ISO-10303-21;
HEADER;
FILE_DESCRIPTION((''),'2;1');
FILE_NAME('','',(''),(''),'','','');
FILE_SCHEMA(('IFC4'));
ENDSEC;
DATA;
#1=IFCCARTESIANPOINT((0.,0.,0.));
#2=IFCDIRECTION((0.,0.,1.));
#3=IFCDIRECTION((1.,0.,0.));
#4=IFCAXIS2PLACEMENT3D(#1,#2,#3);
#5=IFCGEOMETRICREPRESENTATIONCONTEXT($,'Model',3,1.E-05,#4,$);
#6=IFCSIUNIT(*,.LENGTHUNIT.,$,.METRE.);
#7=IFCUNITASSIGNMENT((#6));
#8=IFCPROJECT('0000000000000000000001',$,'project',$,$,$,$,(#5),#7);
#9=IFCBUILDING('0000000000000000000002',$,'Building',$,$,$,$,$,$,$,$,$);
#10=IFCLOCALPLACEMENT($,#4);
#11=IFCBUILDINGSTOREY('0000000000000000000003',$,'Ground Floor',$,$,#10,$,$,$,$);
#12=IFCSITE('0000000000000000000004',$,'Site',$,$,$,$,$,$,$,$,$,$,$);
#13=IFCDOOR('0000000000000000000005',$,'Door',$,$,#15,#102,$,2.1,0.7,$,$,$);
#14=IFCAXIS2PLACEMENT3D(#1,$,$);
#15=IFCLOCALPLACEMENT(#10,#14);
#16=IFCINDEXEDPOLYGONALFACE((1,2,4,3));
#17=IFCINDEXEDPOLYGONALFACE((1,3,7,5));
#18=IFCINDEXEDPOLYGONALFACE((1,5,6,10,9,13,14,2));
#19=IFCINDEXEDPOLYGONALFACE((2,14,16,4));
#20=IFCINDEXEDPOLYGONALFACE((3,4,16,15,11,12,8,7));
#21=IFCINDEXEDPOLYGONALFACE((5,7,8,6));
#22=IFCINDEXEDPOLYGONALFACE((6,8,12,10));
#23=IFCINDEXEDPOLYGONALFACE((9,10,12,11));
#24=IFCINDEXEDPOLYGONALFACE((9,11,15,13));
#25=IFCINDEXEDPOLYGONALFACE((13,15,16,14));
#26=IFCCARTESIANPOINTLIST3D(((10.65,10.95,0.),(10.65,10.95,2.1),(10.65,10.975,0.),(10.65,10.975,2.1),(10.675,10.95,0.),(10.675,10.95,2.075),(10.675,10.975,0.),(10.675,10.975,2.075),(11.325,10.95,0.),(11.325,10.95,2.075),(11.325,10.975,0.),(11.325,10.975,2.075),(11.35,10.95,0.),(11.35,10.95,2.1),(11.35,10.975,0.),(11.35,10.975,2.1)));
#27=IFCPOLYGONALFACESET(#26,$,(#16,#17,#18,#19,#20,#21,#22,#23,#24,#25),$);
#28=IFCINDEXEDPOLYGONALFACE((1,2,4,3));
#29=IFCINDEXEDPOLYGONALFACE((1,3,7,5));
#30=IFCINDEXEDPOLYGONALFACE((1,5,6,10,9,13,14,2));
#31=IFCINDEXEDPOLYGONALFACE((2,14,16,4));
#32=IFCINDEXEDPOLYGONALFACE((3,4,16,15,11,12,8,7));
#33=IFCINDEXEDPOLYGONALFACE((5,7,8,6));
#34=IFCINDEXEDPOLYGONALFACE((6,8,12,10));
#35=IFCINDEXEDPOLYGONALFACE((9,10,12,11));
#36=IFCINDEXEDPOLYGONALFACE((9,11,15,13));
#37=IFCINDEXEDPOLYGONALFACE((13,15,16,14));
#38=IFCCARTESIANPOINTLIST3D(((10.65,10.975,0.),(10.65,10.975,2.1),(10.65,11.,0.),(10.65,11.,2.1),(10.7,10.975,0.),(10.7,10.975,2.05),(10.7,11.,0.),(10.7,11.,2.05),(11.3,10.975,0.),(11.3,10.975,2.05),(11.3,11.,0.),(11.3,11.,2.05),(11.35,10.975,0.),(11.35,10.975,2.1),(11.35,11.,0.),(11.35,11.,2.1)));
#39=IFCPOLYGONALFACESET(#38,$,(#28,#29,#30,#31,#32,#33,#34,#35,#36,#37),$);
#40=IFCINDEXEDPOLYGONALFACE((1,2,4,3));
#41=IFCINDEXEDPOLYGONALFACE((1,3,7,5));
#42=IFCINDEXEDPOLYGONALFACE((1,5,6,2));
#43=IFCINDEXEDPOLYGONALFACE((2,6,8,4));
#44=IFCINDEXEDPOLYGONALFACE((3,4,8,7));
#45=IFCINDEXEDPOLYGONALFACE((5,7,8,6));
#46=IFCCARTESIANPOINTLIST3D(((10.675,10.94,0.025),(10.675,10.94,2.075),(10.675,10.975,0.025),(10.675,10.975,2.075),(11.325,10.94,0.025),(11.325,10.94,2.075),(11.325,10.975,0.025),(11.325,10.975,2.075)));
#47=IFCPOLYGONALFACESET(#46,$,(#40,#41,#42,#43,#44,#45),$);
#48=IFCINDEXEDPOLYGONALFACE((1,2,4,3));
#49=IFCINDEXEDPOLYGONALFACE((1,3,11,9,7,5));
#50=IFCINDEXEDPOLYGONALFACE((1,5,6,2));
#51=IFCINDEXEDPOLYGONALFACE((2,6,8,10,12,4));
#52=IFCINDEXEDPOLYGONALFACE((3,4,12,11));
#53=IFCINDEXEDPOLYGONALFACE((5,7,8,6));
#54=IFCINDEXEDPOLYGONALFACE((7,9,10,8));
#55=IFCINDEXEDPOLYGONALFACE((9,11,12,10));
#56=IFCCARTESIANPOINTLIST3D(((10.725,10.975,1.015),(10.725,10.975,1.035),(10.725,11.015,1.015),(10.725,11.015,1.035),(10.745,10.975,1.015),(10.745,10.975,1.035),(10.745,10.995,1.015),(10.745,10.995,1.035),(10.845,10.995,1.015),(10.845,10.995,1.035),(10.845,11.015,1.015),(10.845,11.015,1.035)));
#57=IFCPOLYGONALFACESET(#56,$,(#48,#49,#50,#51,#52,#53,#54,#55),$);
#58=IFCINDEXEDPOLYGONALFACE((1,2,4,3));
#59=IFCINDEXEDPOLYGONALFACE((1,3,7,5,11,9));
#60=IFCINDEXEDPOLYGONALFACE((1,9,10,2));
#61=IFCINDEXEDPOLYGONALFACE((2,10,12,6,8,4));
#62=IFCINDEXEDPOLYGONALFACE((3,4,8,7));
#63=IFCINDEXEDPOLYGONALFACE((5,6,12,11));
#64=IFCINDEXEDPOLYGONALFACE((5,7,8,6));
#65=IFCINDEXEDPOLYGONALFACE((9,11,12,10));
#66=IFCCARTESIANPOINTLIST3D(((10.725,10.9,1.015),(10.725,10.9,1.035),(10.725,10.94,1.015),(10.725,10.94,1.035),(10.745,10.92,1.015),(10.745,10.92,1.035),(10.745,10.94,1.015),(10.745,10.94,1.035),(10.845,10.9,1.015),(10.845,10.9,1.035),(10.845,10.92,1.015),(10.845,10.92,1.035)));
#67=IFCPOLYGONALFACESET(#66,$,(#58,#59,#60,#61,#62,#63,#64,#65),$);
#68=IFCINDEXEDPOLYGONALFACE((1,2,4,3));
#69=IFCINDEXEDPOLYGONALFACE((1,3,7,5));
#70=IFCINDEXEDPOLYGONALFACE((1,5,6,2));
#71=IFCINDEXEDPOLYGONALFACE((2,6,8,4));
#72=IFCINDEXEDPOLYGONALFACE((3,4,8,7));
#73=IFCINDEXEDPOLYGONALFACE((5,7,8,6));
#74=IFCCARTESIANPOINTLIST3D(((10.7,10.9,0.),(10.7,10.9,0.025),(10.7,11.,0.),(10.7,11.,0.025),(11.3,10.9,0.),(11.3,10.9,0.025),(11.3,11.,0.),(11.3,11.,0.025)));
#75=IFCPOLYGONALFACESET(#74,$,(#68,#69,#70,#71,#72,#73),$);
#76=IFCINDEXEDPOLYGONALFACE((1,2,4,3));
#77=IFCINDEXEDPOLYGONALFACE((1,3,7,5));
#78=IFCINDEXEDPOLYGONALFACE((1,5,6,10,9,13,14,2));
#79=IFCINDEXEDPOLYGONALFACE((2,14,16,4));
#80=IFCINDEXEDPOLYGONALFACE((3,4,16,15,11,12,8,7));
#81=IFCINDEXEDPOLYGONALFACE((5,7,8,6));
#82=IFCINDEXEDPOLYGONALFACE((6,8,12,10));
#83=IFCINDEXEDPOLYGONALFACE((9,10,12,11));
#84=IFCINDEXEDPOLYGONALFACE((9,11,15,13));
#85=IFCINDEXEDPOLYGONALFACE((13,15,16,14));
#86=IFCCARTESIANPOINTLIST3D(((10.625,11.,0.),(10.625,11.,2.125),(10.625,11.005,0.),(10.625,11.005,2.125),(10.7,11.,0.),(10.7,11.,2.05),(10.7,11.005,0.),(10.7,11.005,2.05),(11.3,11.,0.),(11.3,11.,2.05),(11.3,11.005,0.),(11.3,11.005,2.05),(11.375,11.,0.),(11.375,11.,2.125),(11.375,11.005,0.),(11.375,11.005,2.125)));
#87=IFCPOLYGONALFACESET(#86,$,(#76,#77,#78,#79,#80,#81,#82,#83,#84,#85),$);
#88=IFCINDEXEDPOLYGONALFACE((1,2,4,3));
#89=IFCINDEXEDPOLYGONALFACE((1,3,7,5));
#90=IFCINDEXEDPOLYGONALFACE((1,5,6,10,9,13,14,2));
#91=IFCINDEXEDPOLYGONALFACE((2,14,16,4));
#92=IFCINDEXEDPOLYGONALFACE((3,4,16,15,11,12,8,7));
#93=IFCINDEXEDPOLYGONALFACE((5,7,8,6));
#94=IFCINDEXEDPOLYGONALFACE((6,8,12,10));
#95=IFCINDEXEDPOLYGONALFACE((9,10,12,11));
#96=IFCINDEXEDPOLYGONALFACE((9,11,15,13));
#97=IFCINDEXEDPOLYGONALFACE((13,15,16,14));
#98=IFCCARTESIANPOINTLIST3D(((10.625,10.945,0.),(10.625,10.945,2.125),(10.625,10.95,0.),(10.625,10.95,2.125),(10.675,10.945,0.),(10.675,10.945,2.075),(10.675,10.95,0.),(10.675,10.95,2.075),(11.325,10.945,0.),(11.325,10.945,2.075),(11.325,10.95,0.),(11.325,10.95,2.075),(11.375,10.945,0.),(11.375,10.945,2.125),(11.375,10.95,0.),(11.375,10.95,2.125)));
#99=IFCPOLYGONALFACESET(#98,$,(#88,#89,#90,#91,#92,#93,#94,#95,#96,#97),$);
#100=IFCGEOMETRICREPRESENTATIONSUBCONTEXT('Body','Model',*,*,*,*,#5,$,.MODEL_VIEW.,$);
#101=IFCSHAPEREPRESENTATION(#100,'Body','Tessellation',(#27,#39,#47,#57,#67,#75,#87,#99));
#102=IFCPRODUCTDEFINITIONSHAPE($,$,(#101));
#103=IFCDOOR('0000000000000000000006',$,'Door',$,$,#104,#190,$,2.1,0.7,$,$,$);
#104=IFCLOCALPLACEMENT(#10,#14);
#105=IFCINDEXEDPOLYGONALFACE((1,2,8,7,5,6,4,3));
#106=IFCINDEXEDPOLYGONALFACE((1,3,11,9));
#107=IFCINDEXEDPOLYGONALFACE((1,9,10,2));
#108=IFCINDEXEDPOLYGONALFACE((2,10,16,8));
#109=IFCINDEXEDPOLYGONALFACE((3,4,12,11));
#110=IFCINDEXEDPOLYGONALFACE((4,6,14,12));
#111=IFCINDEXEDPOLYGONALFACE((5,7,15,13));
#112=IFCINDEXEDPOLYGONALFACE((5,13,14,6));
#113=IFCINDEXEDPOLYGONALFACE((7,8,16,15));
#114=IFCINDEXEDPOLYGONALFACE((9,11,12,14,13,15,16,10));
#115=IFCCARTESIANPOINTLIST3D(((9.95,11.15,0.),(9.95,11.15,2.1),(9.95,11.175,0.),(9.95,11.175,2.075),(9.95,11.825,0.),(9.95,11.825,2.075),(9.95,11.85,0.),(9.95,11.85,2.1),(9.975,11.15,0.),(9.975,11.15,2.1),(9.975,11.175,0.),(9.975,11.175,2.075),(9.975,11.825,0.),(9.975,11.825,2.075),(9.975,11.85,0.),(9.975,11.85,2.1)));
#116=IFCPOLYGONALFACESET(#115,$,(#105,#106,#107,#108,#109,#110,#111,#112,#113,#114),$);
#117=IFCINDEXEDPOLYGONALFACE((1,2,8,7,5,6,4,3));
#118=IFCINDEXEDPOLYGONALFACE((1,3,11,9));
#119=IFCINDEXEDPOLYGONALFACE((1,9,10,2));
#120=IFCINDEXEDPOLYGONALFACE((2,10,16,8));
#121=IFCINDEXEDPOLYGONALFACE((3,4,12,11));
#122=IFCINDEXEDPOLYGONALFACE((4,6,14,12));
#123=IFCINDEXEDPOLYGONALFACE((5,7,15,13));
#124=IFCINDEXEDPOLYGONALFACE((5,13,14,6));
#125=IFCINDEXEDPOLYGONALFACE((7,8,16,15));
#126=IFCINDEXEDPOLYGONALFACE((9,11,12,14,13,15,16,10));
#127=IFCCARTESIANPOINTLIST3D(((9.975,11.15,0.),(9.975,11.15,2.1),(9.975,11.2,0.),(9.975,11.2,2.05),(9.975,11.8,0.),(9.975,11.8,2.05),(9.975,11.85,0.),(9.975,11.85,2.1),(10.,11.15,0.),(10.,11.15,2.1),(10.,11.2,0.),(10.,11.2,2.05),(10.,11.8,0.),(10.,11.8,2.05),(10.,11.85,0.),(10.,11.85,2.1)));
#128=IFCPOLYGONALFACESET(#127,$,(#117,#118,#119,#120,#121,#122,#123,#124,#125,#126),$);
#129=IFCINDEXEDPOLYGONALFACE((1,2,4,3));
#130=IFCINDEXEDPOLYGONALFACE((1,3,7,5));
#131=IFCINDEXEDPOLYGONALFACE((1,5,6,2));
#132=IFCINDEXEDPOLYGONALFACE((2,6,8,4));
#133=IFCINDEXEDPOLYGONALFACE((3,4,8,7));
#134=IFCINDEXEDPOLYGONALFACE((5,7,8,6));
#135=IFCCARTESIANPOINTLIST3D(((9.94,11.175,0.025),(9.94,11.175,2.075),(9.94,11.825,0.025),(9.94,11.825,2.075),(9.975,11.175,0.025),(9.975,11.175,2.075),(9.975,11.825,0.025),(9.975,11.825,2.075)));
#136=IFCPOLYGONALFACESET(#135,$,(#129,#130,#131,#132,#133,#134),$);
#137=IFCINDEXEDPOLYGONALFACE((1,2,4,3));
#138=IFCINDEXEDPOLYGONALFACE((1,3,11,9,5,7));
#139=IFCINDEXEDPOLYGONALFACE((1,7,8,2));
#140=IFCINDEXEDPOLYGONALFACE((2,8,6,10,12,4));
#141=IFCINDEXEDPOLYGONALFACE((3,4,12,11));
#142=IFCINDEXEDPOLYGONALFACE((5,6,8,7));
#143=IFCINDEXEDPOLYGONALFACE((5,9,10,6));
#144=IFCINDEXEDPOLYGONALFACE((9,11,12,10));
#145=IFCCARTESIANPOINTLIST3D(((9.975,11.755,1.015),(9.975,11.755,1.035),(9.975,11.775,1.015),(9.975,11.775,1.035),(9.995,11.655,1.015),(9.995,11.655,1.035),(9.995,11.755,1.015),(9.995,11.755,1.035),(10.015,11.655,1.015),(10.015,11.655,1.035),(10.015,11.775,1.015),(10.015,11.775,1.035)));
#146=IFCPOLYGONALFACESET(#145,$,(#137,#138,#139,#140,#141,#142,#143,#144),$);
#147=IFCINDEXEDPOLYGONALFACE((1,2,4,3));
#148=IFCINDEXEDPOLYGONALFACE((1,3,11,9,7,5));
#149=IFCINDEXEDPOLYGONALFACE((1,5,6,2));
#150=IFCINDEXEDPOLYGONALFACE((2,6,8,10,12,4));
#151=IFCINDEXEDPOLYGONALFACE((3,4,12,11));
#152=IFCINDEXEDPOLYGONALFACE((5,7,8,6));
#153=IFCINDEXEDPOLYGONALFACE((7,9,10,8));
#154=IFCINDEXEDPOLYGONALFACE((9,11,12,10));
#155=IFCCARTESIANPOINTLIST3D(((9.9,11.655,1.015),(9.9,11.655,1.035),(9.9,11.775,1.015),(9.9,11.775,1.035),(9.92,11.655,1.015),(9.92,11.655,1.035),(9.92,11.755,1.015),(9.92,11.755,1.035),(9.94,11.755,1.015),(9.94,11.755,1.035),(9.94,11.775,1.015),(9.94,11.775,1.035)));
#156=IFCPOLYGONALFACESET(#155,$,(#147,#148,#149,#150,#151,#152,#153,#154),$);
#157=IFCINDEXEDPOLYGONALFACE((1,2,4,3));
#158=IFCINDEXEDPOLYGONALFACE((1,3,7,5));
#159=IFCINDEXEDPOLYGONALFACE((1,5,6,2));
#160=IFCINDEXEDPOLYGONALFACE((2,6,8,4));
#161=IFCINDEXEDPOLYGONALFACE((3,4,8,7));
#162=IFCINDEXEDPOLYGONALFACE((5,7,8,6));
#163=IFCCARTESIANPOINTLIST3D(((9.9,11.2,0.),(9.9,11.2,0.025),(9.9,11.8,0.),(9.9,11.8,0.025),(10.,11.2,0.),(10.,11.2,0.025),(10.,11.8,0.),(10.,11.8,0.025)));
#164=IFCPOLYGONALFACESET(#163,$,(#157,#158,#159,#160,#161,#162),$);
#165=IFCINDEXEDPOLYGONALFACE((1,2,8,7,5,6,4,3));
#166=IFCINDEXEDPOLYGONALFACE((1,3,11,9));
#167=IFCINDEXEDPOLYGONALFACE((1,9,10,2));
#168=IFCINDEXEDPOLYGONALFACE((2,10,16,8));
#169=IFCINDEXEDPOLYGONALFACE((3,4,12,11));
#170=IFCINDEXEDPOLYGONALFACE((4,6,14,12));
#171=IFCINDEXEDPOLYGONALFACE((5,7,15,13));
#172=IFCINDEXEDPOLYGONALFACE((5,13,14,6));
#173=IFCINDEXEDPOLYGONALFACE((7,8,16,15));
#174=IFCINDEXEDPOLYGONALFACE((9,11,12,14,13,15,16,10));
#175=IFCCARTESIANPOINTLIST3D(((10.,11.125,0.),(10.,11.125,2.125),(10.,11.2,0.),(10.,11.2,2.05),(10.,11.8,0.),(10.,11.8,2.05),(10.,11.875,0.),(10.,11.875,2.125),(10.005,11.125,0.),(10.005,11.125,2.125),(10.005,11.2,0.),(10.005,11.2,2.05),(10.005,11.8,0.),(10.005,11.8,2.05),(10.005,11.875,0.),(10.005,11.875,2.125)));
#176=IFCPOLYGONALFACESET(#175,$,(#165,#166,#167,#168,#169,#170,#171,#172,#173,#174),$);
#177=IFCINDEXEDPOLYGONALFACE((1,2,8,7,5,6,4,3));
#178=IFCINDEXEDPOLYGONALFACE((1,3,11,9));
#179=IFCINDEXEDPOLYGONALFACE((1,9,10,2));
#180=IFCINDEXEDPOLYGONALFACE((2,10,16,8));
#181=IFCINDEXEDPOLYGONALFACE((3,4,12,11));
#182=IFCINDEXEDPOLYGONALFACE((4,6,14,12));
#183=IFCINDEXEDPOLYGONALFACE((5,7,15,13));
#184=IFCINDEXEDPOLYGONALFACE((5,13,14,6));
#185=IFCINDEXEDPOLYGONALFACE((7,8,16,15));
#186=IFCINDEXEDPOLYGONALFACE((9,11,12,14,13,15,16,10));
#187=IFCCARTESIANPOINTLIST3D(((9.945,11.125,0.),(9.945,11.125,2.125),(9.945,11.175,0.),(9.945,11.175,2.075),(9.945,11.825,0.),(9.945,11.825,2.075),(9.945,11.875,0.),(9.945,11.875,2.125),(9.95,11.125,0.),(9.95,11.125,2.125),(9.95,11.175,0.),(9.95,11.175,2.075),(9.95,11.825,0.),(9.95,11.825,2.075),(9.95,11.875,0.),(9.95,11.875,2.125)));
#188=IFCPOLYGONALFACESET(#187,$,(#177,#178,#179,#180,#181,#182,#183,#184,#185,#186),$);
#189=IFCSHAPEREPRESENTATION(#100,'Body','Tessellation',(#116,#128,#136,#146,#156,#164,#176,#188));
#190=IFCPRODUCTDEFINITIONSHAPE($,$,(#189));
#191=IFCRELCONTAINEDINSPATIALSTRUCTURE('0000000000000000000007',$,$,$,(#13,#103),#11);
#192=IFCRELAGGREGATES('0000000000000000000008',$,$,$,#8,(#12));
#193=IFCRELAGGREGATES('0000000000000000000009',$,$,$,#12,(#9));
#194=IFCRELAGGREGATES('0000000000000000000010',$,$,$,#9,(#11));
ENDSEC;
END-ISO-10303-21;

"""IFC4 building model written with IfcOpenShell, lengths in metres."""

from ifc_helpers import new_model, si_unit, frame, origin_with_axes, place, context, subcontext, project, spatial, line, indexed_curve, outline, extrude, element, save


model = new_model("IFC4")

# Units and contexts
model_context = context("Model", 3, precision=1e-05, world=origin_with_axes())
body_context = subcontext(model_context, "Body", "Model", "MODEL_VIEW")
ifc_project = project(units=[si_unit("LENGTHUNIT", "METRE")], contexts=[model_context])

# Site, building, storey
site = spatial("IfcSite", under=ifc_project, Name="Site")
building = spatial("IfcBuilding", under=site, Name="Building")
storey_placement = place(None, origin_with_axes())
storey = spatial("IfcBuildingStorey", under=building, at=storey_placement, Name="Ground Floor")

# Doors
door_1_placement = place(storey_placement, frame((11.35, 11.0, 0.0), z_axis=(0.0, 0.0, 1.0), x_axis=(-1.0, 0.0, 0.0)))
element("IfcDoor", 1, at=door_1_placement, inside=storey, Name="Door", OverallHeight=2.1, OverallWidth=0.7, context=body_context, shape_type="SweptSolid", body=[
    extrude(outline(indexed_curve([(0.0, 0.0), (0.0, 2.1), (0.7, 2.1), (0.7, 0.0), (0.675, 0.0), (0.675, 2.075), (0.025, 2.075), (0.025, 0.0)], segments=[line(1, 2, 3, 4, 5, 6, 7, 8, 1)])), frame((0.0, 0.025, 0.0), z_axis=(0.0, -1.0, 0.0), x_axis=(1.0, 0.0, 0.0)), (0.0, 0.0, -1.0), 0.025),
    extrude(outline(indexed_curve([(0.0, 0.0), (0.0, 2.1), (0.7, 2.1), (0.7, 0.0), (0.65, 0.0), (0.65, 2.05), (0.05, 2.05), (0.05, 0.0)], segments=[line(1, 2, 3, 4, 5, 6, 7, 8, 1)])), frame((0.0, 0.0, 0.0), z_axis=(0.0, -1.0, 0.0), x_axis=(1.0, 0.0, 0.0)), (0.0, 0.0, -1.0), 0.025),
    extrude(outline(indexed_curve([(0.0, 0.0), (0.65, 0.0), (0.65, 0.035), (0.0, 0.035)], segments=[line(1, 2, 3, 4, 1)])), frame((0.025, 0.025, 0.025), z_axis=(0.0, 0.0, 1.0), x_axis=(1.0, 0.0, 0.0)), (0.0, 0.0, 1.0), 2.05),
    extrude(outline(indexed_curve([(0.0, 0.0), (0.0, -0.04), (-0.12, -0.04), (-0.12, -0.02), (-0.02, -0.02), (-0.02, 0.0)], segments=[line(1, 2, 3, 4, 5, 6, 1)])), frame((0.625, 0.025, 1.015), z_axis=(0.0, 0.0, 1.0), x_axis=(1.0, 0.0, 0.0)), (0.0, 0.0, 1.0), 0.02),
    extrude(outline(indexed_curve([(0.0, 0.0), (0.0, 0.04), (-0.12, 0.04), (-0.12, 0.02), (-0.02, 0.02), (-0.02, 0.0)], segments=[line(1, 2, 3, 4, 5, 6, 1)])), frame((0.625, 0.06, 1.015), z_axis=(0.0, 0.0, 1.0), x_axis=(1.0, 0.0, 0.0)), (0.0, 0.0, 1.0), 0.02),
    extrude(outline(indexed_curve([(0.0, 0.0), (0.6, 0.0), (0.6, 0.1), (0.0, 0.1)], segments=[line(1, 2, 3, 4, 1)])), frame((0.05, 0.0, 0.0), z_axis=(0.0, 0.0, 1.0), x_axis=(1.0, 0.0, 0.0)), (0.0, 0.0, 1.0), 0.025),
    extrude(outline(indexed_curve([(0.0, 0.0), (0.0, 2.125), (0.75, 2.125), (0.75, 0.0), (0.675, 0.0), (0.675, 2.05), (0.075, 2.05), (0.075, 0.0)], segments=[line(1, 2, 3, 4, 5, 6, 7, 8, 1)])), frame((-0.025, -0.005, 0.0), z_axis=(0.0, -1.0, 0.0), x_axis=(1.0, 0.0, 0.0)), (0.0, 0.0, -1.0), 0.005),
    extrude(outline(indexed_curve([(0.0, 0.0), (0.0, 2.125), (0.75, 2.125), (0.75, 0.0), (0.7, 0.0), (0.7, 2.075), (0.05, 2.075), (0.05, 0.0)], segments=[line(1, 2, 3, 4, 5, 6, 7, 8, 1)])), frame((-0.025, 0.05, 0.0), z_axis=(0.0, -1.0, 0.0), x_axis=(1.0, 0.0, 0.0)), (0.0, 0.0, -1.0), 0.005),
])
door_2_placement = place(storey_placement, frame((10.0, 11.15, 0.0), z_axis=(0.0, 0.0, 1.0), x_axis=(0.0, 1.0, 0.0)))
element("IfcDoor", 2, at=door_2_placement, inside=storey, Name="Door", OverallHeight=2.1, OverallWidth=0.7, context=body_context, shape_type="SweptSolid", body=[
    extrude(outline(indexed_curve([(0.0, 0.0), (0.0, 2.1), (0.7, 2.1), (0.7, 0.0), (0.675, 0.0), (0.675, 2.075), (0.025, 2.075), (0.025, 0.0)], segments=[line(1, 2, 3, 4, 5, 6, 7, 8, 1)])), frame((0.0, 0.025, 0.0), z_axis=(0.0, -1.0, 0.0), x_axis=(1.0, 0.0, 0.0)), (0.0, 0.0, -1.0), 0.025),
    extrude(outline(indexed_curve([(0.0, 0.0), (0.0, 2.1), (0.7, 2.1), (0.7, 0.0), (0.65, 0.0), (0.65, 2.05), (0.05, 2.05), (0.05, 0.0)], segments=[line(1, 2, 3, 4, 5, 6, 7, 8, 1)])), frame((0.0, 0.0, 0.0), z_axis=(0.0, -1.0, 0.0), x_axis=(1.0, 0.0, 0.0)), (0.0, 0.0, -1.0), 0.025),
    extrude(outline(indexed_curve([(0.0, 0.0), (0.65, 0.0), (0.65, 0.035), (0.0, 0.035)], segments=[line(1, 2, 3, 4, 1)])), frame((0.025, 0.025, 0.025), z_axis=(0.0, 0.0, 1.0), x_axis=(1.0, 0.0, 0.0)), (0.0, 0.0, 1.0), 2.05),
    extrude(outline(indexed_curve([(0.0, 0.0), (0.0, -0.04), (-0.12, -0.04), (-0.12, -0.02), (-0.02, -0.02), (-0.02, 0.0)], segments=[line(1, 2, 3, 4, 5, 6, 1)])), frame((0.625, 0.025, 1.015), z_axis=(0.0, 0.0, 1.0), x_axis=(1.0, 0.0, 0.0)), (0.0, 0.0, 1.0), 0.02),
    extrude(outline(indexed_curve([(0.0, 0.0), (0.0, 0.04), (-0.12, 0.04), (-0.12, 0.02), (-0.02, 0.02), (-0.02, 0.0)], segments=[line(1, 2, 3, 4, 5, 6, 1)])), frame((0.625, 0.06, 1.015), z_axis=(0.0, 0.0, 1.0), x_axis=(1.0, 0.0, 0.0)), (0.0, 0.0, 1.0), 0.02),
    extrude(outline(indexed_curve([(0.0, 0.0), (0.6, 0.0), (0.6, 0.1), (0.0, 0.1)], segments=[line(1, 2, 3, 4, 1)])), frame((0.05, 0.0, 0.0), z_axis=(0.0, 0.0, 1.0), x_axis=(1.0, 0.0, 0.0)), (0.0, 0.0, 1.0), 0.025),
    extrude(outline(indexed_curve([(0.0, 0.0), (0.0, 2.125), (0.75, 2.125), (0.75, 0.0), (0.675, 0.0), (0.675, 2.05), (0.075, 2.05), (0.075, 0.0)], segments=[line(1, 2, 3, 4, 5, 6, 7, 8, 1)])), frame((-0.025, -0.005, 0.0), z_axis=(0.0, -1.0, 0.0), x_axis=(1.0, 0.0, 0.0)), (0.0, 0.0, -1.0), 0.005),
    extrude(outline(indexed_curve([(0.0, 0.0), (0.0, 2.125), (0.75, 2.125), (0.75, 0.0), (0.7, 0.0), (0.7, 2.075), (0.05, 2.075), (0.05, 0.0)], segments=[line(1, 2, 3, 4, 5, 6, 7, 8, 1)])), frame((-0.025, 0.05, 0.0), z_axis=(0.0, -1.0, 0.0), x_axis=(1.0, 0.0, 0.0)), (0.0, 0.0, -1.0), 0.005),
])

save(model, "model.ifc")
